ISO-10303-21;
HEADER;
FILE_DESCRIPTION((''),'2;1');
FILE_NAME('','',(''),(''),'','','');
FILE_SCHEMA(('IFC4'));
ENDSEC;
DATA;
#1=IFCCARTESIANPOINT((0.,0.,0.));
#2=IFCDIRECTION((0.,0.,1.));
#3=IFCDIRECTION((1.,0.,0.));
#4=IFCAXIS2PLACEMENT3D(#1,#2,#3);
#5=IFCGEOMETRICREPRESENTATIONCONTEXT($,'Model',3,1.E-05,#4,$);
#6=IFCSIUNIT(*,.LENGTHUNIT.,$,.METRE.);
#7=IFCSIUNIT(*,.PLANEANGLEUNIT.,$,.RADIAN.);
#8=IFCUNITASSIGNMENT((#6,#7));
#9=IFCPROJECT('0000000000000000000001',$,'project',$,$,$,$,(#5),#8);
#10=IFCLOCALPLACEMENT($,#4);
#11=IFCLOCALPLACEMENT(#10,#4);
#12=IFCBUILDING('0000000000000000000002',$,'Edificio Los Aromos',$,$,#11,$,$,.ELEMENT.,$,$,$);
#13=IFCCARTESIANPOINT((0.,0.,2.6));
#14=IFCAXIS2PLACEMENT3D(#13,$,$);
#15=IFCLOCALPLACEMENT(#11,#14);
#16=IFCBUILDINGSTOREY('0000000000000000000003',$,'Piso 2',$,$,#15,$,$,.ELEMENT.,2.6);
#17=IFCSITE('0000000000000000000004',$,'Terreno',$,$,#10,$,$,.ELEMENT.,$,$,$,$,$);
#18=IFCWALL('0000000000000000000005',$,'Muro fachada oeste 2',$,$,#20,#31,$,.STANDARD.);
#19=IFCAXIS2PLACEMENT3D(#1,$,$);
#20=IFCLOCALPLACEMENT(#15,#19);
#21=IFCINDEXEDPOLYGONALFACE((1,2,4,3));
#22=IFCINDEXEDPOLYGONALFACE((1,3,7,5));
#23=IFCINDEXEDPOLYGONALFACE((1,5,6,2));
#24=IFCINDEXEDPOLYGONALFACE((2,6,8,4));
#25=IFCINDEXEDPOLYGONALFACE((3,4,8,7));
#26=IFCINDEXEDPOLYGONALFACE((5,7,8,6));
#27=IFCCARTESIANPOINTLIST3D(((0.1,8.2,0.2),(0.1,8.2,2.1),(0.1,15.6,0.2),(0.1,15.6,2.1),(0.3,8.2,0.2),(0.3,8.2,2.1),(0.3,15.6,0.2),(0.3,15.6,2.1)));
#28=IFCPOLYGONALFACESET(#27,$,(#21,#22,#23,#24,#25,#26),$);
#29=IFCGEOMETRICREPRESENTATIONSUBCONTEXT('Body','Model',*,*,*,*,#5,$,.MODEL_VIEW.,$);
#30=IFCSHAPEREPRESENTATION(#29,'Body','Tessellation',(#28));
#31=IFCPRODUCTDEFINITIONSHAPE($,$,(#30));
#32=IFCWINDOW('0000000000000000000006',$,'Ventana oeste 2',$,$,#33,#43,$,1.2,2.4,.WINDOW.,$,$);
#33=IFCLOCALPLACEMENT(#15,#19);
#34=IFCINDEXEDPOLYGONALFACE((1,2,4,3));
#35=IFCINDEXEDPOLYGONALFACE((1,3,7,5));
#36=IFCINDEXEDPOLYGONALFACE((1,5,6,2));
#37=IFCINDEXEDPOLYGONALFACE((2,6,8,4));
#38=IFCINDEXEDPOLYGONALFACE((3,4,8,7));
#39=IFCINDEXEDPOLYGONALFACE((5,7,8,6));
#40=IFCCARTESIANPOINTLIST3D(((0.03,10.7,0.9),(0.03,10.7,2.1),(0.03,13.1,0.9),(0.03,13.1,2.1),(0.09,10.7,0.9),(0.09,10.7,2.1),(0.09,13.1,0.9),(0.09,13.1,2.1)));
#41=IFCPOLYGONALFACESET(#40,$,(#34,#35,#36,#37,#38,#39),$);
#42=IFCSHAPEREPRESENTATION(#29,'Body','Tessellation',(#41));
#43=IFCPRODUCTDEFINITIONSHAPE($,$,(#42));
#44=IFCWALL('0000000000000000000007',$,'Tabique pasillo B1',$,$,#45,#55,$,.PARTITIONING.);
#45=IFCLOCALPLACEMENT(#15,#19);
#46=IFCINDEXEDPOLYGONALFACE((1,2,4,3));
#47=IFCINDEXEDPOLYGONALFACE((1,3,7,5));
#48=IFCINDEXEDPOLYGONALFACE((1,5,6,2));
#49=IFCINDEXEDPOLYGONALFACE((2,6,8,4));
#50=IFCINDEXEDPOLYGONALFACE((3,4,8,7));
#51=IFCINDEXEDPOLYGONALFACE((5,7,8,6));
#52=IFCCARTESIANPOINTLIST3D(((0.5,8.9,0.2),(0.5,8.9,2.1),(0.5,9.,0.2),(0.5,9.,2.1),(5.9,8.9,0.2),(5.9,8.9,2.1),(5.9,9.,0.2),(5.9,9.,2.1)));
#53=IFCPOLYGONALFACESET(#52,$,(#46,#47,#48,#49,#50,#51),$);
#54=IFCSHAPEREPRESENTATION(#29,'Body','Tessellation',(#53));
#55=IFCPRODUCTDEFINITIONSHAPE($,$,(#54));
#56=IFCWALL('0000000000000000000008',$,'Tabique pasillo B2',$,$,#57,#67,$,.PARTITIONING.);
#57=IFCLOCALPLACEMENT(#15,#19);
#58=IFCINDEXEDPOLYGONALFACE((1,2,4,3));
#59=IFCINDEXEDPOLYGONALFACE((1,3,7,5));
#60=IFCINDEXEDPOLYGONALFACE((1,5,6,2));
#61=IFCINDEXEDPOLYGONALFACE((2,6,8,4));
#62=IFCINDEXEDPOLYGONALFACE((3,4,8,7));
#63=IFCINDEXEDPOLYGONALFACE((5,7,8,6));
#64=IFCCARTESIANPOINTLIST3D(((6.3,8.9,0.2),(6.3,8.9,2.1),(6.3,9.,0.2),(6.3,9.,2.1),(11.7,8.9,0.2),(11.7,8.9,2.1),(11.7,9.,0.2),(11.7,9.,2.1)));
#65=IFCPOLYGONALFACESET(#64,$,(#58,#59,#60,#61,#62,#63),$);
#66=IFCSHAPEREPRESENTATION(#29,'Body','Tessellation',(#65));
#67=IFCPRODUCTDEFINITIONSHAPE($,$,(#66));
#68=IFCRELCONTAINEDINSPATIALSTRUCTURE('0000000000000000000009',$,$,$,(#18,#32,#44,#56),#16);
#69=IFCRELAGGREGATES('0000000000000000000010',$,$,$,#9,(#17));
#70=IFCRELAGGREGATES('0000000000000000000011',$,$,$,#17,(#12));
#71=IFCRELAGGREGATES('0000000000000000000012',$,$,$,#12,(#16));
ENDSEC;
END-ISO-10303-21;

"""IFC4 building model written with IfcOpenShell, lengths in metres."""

from ifc_helpers import new_model, si_unit, frame, frame_2d, origin_with_axes, place, context, subcontext, project, spatial, rectangle, extrude, element, save


model = new_model("IFC4")

# Units and contexts
model_context = context("Model", 3, precision=1e-05, world=origin_with_axes())
body_context = subcontext(model_context, "Body", "Model", "MODEL_VIEW")
ifc_project = project(units=[si_unit("LENGTHUNIT", "METRE"), si_unit("PLANEANGLEUNIT", "RADIAN")], contexts=[model_context])

# Site, building, storey
site_placement = place(None, origin_with_axes())
site = spatial("IfcSite", under=ifc_project, at=site_placement, Name="Terreno", CompositionType="ELEMENT")
building_placement = place(site_placement, origin_with_axes())
building = spatial("IfcBuilding", under=site, at=building_placement, Name="Edificio Los Aromos", CompositionType="ELEMENT")
storey_placement = place(building_placement, frame((0.0, 0.0, 2.6)))
storey = spatial("IfcBuildingStorey", under=building, at=storey_placement, Name="Piso 2", CompositionType="ELEMENT", Elevation=2.6)

# Wall
wall_1_placement = place(storey_placement, frame((0.1, 8.2, 0.2)))
element("IfcWall", 1, at=wall_1_placement, inside=storey, Name="Muro fachada oeste 2", PredefinedType="STANDARD", context=body_context, shape_type="SweptSolid", body=[
    extrude(rectangle(XDim=0.2, YDim=7.4, at=frame_2d((0.1, 3.7))), origin_with_axes(), (0.0, 0.0, 1.0), 1.9),
])

# Window
window_1_placement = place(storey_placement, frame((0.03, 10.7, 0.9)))
element("IfcWindow", 2, at=window_1_placement, inside=storey, Name="Ventana oeste 2", OverallHeight=1.2, OverallWidth=2.4, PredefinedType="WINDOW", context=body_context, shape_type="SweptSolid", body=[
    extrude(rectangle(XDim=0.06, YDim=2.4, at=frame_2d((0.03, 1.2))), origin_with_axes(), (0.0, 0.0, 1.0), 1.2),
])

# Walls
for number, where, name in (
    (3, (0.5, 8.9, 0.2), "Tabique pasillo B1"),
    (4, (6.3, 8.9, 0.2), "Tabique pasillo B2"),
):
    element("IfcWall", number, at=place(storey_placement, frame(where)), inside=storey, Name=name, PredefinedType="PARTITIONING", context=body_context, shape_type="SweptSolid", body=[
        extrude(rectangle(XDim=5.4, YDim=0.1, at=frame_2d((2.7, 0.05))), origin_with_axes(), (0.0, 0.0, 1.0), 1.9),
    ])

save(model, "model.ifc")
